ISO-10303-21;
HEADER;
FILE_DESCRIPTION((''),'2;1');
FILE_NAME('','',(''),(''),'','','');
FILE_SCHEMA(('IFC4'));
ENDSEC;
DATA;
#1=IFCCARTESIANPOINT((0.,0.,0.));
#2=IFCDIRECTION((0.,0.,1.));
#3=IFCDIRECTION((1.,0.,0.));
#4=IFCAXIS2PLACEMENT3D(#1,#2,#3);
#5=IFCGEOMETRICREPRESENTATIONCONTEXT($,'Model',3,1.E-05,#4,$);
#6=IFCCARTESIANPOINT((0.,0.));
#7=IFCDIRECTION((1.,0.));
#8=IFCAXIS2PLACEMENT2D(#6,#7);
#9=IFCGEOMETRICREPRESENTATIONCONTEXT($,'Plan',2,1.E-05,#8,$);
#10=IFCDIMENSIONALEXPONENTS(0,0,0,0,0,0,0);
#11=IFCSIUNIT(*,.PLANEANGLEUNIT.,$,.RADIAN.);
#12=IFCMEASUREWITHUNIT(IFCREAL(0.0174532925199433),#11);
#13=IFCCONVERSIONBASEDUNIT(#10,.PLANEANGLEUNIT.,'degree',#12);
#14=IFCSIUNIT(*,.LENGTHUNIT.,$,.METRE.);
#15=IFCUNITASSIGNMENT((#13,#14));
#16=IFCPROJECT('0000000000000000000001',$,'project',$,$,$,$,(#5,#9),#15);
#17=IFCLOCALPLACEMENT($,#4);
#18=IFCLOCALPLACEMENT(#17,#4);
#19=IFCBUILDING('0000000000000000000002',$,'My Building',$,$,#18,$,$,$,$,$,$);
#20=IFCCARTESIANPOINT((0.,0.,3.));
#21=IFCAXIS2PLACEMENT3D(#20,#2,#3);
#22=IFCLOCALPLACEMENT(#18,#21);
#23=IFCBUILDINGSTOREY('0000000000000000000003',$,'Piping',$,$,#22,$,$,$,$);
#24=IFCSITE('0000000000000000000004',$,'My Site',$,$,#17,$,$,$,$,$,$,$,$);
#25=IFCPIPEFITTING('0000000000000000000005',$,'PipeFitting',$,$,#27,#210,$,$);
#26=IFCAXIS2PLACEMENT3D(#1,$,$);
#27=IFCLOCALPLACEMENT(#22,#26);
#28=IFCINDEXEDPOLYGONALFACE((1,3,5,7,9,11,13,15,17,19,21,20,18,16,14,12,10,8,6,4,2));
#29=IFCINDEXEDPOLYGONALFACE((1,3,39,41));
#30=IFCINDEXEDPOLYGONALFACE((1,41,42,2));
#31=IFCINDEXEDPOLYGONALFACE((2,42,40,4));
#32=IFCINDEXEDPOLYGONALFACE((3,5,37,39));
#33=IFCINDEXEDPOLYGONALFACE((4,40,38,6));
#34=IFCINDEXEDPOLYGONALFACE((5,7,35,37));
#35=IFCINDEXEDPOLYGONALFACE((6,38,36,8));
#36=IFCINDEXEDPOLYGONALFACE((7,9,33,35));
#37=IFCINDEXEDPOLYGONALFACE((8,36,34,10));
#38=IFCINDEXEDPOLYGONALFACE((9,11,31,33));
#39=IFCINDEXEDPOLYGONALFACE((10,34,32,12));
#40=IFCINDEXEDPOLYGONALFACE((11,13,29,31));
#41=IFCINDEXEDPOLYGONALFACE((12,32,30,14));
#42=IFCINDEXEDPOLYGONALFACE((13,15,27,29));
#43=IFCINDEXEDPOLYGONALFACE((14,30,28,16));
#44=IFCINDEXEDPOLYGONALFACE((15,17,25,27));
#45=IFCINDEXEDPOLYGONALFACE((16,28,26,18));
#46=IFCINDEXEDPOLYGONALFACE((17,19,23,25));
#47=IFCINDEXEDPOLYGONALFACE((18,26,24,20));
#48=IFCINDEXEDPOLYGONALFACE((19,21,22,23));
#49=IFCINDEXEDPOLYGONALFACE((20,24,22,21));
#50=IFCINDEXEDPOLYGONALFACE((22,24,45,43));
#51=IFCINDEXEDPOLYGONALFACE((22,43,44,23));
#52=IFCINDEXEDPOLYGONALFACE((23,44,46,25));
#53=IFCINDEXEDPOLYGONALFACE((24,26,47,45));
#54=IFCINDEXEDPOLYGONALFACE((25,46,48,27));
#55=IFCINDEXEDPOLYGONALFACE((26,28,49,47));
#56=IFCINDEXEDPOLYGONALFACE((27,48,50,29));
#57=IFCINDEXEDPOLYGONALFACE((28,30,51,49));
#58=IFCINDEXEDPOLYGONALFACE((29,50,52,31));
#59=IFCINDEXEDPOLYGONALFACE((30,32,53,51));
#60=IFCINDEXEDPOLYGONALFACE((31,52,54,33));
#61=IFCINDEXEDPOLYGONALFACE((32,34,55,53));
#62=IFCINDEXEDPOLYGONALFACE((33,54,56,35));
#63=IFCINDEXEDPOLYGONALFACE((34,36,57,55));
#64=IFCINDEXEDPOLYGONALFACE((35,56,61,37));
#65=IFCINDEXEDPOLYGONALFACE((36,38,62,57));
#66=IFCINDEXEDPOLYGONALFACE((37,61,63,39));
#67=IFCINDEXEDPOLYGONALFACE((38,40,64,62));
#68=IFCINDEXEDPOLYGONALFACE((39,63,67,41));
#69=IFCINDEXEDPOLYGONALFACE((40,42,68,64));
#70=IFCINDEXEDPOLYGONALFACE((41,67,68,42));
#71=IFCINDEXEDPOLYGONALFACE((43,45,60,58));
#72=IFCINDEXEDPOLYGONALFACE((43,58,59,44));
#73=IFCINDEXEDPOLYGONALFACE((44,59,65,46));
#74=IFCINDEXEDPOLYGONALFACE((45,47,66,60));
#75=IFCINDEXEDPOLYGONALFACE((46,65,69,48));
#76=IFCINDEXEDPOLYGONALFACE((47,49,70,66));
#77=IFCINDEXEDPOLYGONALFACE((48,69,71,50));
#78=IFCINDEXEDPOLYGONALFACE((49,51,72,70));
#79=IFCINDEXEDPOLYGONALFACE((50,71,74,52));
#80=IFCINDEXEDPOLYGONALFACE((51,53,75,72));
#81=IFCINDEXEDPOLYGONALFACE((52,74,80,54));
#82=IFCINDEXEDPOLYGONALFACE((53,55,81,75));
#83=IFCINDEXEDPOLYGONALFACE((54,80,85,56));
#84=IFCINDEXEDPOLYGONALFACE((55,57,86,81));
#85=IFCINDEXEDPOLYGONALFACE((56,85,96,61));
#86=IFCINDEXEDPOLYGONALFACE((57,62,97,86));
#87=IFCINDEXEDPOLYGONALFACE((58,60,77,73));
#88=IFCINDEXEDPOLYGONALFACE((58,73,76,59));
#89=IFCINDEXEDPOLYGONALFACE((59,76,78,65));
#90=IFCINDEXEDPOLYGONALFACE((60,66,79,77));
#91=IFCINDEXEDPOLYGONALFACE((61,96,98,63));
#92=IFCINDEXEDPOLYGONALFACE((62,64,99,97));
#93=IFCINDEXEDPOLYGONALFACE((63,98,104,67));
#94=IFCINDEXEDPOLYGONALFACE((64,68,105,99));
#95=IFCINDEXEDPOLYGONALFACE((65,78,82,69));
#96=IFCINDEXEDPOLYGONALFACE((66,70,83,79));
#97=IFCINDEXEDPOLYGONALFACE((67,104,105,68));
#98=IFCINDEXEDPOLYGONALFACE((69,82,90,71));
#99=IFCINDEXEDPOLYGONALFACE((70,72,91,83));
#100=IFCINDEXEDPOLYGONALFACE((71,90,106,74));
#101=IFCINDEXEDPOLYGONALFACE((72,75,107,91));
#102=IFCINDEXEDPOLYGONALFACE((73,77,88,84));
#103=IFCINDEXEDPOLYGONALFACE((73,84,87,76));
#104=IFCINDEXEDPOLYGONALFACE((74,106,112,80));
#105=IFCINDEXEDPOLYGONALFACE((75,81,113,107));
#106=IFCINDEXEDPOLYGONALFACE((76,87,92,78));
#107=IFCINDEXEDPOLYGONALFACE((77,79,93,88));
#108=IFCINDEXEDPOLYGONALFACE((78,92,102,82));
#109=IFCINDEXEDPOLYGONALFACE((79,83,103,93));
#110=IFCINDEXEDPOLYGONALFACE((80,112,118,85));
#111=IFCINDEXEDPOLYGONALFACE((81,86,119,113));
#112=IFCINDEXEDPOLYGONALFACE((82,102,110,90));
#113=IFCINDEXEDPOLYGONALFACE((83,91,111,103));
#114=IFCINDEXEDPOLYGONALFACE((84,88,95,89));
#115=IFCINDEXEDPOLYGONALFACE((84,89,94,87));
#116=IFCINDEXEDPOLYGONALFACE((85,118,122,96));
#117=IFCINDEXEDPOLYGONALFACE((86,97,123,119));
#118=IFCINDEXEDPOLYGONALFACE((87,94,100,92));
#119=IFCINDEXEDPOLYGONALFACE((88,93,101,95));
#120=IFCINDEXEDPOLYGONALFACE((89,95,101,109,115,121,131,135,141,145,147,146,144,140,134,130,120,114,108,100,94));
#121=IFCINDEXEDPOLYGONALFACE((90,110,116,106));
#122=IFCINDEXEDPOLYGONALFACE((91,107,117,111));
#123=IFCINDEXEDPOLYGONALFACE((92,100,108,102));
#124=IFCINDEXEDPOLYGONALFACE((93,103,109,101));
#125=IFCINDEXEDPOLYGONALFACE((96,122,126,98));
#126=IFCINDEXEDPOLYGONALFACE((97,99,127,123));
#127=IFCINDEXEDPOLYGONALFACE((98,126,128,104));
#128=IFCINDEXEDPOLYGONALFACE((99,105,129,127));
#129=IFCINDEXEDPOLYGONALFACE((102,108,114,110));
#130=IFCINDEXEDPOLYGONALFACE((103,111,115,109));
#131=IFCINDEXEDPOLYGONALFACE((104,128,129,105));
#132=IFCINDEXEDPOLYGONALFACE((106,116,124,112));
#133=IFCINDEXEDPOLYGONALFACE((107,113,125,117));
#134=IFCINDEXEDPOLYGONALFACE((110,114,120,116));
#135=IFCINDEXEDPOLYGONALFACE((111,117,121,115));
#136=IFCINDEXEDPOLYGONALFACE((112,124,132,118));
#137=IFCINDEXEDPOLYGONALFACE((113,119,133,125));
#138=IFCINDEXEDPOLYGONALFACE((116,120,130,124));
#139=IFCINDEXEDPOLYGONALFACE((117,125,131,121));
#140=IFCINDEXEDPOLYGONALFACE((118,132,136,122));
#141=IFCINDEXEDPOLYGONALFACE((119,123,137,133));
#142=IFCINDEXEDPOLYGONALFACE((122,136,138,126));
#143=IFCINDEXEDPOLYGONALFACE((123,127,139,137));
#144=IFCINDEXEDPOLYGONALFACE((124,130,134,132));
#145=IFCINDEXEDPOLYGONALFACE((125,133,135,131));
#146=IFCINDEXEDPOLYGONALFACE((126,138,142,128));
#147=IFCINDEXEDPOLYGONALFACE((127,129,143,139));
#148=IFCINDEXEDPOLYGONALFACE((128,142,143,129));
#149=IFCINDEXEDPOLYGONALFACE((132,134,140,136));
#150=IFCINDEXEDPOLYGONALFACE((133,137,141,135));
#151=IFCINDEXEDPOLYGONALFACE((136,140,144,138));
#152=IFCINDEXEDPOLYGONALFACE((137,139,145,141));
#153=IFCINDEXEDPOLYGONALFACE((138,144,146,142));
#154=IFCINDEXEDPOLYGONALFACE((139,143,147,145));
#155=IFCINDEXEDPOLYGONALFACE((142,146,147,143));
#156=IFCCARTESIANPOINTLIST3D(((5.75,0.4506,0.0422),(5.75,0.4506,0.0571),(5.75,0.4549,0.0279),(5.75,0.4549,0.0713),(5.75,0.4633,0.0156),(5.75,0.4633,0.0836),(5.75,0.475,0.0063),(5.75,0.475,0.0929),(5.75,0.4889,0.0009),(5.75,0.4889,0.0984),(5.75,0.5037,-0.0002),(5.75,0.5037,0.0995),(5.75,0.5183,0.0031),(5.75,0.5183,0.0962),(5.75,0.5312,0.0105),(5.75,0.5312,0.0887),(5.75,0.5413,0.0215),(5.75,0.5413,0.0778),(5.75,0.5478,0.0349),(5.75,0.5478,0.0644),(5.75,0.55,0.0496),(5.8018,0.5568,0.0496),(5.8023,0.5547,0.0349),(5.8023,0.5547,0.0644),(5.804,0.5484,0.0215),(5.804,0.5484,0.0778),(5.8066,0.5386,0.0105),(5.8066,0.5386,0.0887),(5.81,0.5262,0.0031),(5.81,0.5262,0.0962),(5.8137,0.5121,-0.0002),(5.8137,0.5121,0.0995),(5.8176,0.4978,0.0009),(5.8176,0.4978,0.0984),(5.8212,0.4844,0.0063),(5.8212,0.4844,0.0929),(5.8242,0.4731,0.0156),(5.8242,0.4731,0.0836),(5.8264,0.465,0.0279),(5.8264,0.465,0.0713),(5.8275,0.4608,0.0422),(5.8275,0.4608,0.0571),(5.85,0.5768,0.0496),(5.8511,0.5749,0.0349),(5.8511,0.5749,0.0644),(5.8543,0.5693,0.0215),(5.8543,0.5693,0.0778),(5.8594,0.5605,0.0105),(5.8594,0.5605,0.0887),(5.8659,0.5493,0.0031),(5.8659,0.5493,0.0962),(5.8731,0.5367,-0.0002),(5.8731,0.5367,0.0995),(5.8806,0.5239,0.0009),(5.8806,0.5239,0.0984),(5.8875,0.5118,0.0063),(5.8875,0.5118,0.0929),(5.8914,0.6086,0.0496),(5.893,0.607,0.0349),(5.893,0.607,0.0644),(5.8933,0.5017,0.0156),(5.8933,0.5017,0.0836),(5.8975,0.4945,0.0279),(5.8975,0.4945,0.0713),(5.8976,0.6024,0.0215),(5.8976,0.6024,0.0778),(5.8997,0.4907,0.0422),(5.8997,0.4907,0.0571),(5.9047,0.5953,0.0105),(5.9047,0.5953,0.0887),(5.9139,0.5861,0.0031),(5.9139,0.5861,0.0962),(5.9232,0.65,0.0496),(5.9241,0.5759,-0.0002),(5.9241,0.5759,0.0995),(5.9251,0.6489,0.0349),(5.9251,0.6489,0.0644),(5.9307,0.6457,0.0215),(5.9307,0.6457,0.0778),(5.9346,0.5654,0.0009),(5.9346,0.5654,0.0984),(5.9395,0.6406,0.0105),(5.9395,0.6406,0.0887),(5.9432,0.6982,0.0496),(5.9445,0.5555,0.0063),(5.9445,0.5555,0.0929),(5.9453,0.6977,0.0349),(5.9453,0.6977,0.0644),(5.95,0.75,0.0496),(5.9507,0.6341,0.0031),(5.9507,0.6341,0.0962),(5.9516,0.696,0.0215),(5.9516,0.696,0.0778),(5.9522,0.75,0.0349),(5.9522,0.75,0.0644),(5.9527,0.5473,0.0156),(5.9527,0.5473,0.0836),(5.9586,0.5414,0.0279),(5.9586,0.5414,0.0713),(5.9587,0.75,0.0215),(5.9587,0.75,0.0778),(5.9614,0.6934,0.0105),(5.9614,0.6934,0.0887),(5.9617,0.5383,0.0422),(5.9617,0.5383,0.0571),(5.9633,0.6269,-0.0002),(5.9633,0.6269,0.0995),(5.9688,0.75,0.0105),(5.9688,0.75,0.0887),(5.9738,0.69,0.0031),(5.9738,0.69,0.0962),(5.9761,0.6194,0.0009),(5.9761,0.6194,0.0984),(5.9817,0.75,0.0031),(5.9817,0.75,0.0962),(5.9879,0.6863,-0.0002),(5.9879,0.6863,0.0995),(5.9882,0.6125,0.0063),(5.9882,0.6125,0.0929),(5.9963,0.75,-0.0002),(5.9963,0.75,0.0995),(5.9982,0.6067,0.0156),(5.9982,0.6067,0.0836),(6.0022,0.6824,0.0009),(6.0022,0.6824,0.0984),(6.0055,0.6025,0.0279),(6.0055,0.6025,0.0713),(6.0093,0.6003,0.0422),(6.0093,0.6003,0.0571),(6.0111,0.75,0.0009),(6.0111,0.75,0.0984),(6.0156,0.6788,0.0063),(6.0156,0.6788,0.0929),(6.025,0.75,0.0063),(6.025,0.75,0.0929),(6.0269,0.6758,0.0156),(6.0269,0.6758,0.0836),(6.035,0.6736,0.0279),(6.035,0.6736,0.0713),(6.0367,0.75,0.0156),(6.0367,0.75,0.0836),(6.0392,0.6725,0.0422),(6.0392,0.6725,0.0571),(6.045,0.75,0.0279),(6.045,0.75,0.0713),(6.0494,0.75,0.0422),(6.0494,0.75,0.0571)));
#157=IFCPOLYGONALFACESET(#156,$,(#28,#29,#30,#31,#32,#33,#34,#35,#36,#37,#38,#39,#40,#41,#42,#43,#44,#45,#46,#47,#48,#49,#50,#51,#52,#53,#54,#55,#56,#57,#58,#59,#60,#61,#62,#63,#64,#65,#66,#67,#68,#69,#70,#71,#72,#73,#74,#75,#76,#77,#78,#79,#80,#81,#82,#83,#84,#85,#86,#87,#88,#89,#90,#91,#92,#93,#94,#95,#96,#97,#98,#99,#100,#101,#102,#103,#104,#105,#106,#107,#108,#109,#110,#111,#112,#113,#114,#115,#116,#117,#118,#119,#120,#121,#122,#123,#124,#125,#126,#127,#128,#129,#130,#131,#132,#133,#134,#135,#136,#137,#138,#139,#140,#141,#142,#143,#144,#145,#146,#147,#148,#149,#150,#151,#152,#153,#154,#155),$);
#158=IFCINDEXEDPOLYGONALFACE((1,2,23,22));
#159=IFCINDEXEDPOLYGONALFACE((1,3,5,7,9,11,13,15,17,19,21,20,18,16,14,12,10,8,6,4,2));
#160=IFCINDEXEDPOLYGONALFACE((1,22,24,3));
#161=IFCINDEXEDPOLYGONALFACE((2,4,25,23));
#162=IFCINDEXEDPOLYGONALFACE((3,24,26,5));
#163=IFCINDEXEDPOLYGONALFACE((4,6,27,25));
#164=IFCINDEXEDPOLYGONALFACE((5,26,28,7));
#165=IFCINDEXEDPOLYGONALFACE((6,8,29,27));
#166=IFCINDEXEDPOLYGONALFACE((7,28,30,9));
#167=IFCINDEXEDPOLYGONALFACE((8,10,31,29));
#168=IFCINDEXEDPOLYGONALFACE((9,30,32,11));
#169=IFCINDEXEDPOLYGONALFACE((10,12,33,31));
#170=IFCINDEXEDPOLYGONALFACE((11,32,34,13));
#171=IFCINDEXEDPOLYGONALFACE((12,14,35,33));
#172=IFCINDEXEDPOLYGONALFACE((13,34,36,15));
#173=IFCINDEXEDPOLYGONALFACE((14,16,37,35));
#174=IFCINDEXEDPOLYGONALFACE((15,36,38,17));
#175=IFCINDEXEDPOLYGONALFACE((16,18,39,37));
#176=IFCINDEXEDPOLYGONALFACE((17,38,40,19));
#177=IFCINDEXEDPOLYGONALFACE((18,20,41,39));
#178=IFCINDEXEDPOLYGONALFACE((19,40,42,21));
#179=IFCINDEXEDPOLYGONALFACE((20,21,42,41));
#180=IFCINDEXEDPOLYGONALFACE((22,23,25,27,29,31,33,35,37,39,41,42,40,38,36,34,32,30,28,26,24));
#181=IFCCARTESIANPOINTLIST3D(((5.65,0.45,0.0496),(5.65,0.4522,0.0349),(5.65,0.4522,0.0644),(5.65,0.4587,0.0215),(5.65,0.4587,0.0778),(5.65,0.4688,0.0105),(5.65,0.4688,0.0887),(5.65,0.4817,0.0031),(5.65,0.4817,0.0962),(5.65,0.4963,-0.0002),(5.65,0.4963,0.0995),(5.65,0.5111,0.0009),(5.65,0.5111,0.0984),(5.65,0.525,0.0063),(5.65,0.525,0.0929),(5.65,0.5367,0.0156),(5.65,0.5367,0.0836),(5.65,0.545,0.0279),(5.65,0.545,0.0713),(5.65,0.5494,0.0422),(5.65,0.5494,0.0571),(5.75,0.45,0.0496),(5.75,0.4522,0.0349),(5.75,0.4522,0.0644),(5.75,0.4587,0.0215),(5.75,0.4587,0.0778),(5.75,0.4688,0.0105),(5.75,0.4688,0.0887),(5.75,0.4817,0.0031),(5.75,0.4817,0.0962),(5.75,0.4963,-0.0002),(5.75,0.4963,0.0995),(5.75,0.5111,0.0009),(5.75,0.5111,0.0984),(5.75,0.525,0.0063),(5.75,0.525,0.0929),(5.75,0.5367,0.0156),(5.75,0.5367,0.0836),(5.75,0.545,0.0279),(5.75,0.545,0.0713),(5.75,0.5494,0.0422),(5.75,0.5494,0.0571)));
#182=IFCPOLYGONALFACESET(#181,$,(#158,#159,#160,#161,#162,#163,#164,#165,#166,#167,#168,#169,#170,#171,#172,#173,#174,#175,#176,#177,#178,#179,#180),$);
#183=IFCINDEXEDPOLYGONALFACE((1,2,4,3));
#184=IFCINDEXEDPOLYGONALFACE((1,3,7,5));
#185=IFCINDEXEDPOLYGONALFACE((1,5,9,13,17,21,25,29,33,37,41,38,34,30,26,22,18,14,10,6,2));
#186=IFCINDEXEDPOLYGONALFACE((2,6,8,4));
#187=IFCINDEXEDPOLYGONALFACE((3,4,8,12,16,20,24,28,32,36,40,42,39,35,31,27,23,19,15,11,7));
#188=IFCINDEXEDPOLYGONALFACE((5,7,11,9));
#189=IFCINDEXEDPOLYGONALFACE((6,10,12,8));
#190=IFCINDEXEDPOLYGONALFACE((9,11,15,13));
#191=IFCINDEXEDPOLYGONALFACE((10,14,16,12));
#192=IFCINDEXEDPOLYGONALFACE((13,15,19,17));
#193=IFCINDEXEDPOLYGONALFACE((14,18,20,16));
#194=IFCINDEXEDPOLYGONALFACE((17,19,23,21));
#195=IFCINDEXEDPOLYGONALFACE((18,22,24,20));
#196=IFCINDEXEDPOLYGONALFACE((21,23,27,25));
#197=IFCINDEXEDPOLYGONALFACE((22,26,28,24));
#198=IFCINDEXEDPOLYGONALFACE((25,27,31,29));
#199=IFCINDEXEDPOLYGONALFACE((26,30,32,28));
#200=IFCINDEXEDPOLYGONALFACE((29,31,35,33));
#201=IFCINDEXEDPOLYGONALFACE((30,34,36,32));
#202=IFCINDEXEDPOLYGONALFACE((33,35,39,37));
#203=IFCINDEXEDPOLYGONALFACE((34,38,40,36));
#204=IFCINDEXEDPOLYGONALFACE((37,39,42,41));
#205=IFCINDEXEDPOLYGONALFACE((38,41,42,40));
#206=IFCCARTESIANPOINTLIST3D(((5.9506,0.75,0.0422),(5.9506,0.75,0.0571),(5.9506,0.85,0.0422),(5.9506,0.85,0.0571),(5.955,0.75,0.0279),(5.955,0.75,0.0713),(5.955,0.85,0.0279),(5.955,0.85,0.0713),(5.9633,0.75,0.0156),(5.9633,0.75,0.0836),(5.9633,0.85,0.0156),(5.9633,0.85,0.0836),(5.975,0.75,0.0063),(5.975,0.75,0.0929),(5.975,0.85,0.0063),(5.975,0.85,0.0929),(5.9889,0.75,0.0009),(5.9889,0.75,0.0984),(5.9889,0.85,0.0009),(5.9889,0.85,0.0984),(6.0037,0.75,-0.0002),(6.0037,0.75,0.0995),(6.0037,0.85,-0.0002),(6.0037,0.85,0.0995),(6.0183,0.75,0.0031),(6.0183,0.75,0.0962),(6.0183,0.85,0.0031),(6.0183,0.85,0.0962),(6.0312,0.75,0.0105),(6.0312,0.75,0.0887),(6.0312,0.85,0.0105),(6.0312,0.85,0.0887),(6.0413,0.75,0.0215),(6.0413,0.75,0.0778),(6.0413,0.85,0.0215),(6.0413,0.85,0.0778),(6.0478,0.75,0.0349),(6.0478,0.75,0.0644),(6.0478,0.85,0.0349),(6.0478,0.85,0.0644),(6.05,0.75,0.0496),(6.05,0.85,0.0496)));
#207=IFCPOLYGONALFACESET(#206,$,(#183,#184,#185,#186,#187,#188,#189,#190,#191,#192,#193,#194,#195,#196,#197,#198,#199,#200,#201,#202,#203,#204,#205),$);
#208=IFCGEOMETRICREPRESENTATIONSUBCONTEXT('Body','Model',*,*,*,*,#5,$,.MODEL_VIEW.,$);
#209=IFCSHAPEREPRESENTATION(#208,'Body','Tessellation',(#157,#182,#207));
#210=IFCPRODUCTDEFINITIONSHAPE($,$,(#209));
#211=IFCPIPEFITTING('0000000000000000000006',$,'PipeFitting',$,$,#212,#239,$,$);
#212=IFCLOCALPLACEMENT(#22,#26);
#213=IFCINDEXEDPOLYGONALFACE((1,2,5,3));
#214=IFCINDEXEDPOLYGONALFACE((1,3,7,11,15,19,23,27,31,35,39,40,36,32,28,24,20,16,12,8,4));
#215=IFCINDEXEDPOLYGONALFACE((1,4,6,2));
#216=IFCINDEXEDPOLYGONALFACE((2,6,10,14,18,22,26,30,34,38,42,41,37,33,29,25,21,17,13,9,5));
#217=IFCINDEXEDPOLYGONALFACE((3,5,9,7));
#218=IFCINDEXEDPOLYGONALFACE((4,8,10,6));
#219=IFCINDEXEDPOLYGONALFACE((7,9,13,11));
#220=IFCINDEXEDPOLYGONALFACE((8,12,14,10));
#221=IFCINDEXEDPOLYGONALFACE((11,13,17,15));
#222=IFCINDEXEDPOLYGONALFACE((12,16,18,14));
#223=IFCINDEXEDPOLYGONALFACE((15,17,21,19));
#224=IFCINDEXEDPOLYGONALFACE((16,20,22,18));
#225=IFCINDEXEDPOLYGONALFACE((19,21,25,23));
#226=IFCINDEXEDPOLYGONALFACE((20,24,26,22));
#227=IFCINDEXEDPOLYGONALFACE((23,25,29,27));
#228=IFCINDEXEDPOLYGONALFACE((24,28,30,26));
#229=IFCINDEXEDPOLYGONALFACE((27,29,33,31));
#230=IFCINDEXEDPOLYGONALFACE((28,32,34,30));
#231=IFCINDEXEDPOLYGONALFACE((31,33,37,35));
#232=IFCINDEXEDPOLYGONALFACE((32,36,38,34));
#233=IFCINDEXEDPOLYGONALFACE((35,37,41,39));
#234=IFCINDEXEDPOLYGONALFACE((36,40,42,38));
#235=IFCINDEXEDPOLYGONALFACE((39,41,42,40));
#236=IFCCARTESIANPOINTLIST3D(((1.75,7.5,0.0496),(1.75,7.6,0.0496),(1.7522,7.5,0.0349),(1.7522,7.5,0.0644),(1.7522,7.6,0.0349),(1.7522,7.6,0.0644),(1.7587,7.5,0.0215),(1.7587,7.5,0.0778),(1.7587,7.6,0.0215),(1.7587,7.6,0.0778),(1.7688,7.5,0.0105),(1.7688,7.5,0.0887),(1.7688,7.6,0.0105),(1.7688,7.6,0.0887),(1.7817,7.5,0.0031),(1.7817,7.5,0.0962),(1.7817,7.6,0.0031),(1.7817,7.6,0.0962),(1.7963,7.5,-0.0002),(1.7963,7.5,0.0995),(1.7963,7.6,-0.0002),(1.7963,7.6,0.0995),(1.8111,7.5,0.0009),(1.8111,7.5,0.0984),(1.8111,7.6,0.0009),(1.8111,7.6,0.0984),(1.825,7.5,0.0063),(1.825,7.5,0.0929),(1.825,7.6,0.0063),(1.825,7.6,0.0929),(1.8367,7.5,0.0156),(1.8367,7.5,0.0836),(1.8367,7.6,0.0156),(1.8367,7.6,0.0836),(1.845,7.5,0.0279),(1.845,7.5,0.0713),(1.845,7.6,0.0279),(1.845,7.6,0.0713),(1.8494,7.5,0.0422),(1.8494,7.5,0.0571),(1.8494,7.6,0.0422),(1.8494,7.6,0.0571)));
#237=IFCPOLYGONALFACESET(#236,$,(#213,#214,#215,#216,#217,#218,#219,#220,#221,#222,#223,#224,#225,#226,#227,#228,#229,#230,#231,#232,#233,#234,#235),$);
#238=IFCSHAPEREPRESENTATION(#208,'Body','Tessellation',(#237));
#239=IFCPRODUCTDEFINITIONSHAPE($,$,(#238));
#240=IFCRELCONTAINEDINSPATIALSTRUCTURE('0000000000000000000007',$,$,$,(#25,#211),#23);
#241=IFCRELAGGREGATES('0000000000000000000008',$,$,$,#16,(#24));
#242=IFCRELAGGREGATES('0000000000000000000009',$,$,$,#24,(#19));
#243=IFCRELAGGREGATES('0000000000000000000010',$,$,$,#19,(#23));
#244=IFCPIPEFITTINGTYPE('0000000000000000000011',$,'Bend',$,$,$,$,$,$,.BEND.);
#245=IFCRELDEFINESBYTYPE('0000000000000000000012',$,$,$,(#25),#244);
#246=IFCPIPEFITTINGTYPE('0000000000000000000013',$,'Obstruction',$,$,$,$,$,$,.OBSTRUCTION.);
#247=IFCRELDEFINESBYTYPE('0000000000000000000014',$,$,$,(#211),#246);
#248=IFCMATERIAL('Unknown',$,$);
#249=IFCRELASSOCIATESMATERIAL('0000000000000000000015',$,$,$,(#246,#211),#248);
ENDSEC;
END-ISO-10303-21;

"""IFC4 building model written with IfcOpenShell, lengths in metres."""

from ifc_helpers import new_model, entity, si_unit, converted_unit, frame, origin_with_axes, origin_2d_with_axis, place, context, subcontext, project, spatial, circle, extrude, source, transform, mapped, material, material_profile, profile_set, profile_usage, type_object, type_shapes, element, save


model = new_model("IFC4")

# Units and contexts
model_context = context("Model", 3, precision=1e-05, world=origin_with_axes())
plan_context = context("Plan", 2, precision=1e-05, world=origin_2d_with_axis())
body_context = subcontext(model_context, "Body", "Model", "MODEL_VIEW")
ifc_project = project(units=[converted_unit("PLANEANGLEUNIT", "degree", entity("IfcReal", 0.0174532925199433), si_unit("PLANEANGLEUNIT", "RADIAN"), dimensions=[0, 0, 0, 0, 0, 0, 0]), si_unit("LENGTHUNIT", "METRE")], contexts=[model_context, plan_context])

# Site, building, storey
site_placement = place(None, origin_with_axes())
site = spatial("IfcSite", under=ifc_project, at=site_placement, Name="My Site")
building_placement = place(site_placement, origin_with_axes())
building = spatial("IfcBuilding", under=site, at=building_placement, Name="My Building")
storey_placement = place(building_placement, frame((0.0, 0.0, 3.0), z_axis=(0.0, 0.0, 1.0), x_axis=(1.0, 0.0, 0.0)))
storey = spatial("IfcBuildingStorey", under=building, at=storey_placement, Name="Piping")

# Shared definitions
ifc_material = material(Name="Unknown")

# Pipe fittings
pipe_fitting_type_1 = type_object("IfcPipeFittingType", Name="Bend", PredefinedType="BEND")
shared_shape = source(origin_with_axes(), body_context, "Body", "SolidModel", [
    entity("IfcSweptDiskSolid", entity("IfcIndexedPolyCurve", entity("IfcCartesianPointList3D", [[0.0, 0.0, -0.1], [-0.0732, 0.0, -0.2768], [-0.25, 0.0, -0.35]]), [entity("IfcArcIndex", [1, 2, 3])]), 0.05),
    extrude(circle(Radius=0.05), origin_with_axes(), (0.0, 0.0, -1.0), 0.1),
    extrude(circle(Radius=0.05), frame((-0.25, 0.0, -0.35), z_axis=(-1.0, 0.0, 0.0), x_axis=(0.0, 0.0, -1.0)), (0.0, 0.0, 1.0), 0.1),
])
type_shapes(pipe_fitting_type_1, [shared_shape])
for number, where, z_axis, x_axis, name in (
    (1, (5.65, 0.5, 0.0496), (-1.0, -0.000001, 0.0), (0.000001, -1.0, 0.0), "PipeFitting"),
):
    element("IfcPipeFitting", number, at=place(storey_placement, frame(where, z_axis=z_axis, x_axis=x_axis)), inside=storey, type_object=pipe_fitting_type_1, Name=name, context=body_context, shape_type="MappedRepresentation", body=[
        mapped(shared_shape, transform((0.0, 0.0, 0.0), x_axis=(1.0, 0.0, 0.0), y_axis=(0.0, 1.0, 0.0), z_axis=(0.0, 0.0, 1.0), scale=1.0)),
    ])
ifc_material_profile_1 = material_profile(ifc_material, circle(Radius=0.05))
ifc_profile_set_1 = profile_set([ifc_material_profile_1])
ifc_profile_usage_1 = profile_usage(ifc_profile_set_1, cardinal=5)
pipe_fitting_type_2 = type_object("IfcPipeFittingType", Name="Obstruction", PredefinedType="OBSTRUCTION", material=ifc_profile_set_1)
pipe_fitting_1_placement = place(storey_placement, frame((1.8, 7.5, 0.0496), z_axis=(0.0, 1.0, 0.0), x_axis=(-1.0, 0.0, 0.0)))
element("IfcPipeFitting", 2, at=pipe_fitting_1_placement, inside=storey, type_object=pipe_fitting_type_2, material=ifc_profile_usage_1, Name="PipeFitting", context=body_context, shape_type="SweptSolid", body=[
    extrude(circle(Radius=0.05), origin_with_axes(), (0.0, 0.0, 1.0), 0.1),
])

save(model, "model.ifc")
